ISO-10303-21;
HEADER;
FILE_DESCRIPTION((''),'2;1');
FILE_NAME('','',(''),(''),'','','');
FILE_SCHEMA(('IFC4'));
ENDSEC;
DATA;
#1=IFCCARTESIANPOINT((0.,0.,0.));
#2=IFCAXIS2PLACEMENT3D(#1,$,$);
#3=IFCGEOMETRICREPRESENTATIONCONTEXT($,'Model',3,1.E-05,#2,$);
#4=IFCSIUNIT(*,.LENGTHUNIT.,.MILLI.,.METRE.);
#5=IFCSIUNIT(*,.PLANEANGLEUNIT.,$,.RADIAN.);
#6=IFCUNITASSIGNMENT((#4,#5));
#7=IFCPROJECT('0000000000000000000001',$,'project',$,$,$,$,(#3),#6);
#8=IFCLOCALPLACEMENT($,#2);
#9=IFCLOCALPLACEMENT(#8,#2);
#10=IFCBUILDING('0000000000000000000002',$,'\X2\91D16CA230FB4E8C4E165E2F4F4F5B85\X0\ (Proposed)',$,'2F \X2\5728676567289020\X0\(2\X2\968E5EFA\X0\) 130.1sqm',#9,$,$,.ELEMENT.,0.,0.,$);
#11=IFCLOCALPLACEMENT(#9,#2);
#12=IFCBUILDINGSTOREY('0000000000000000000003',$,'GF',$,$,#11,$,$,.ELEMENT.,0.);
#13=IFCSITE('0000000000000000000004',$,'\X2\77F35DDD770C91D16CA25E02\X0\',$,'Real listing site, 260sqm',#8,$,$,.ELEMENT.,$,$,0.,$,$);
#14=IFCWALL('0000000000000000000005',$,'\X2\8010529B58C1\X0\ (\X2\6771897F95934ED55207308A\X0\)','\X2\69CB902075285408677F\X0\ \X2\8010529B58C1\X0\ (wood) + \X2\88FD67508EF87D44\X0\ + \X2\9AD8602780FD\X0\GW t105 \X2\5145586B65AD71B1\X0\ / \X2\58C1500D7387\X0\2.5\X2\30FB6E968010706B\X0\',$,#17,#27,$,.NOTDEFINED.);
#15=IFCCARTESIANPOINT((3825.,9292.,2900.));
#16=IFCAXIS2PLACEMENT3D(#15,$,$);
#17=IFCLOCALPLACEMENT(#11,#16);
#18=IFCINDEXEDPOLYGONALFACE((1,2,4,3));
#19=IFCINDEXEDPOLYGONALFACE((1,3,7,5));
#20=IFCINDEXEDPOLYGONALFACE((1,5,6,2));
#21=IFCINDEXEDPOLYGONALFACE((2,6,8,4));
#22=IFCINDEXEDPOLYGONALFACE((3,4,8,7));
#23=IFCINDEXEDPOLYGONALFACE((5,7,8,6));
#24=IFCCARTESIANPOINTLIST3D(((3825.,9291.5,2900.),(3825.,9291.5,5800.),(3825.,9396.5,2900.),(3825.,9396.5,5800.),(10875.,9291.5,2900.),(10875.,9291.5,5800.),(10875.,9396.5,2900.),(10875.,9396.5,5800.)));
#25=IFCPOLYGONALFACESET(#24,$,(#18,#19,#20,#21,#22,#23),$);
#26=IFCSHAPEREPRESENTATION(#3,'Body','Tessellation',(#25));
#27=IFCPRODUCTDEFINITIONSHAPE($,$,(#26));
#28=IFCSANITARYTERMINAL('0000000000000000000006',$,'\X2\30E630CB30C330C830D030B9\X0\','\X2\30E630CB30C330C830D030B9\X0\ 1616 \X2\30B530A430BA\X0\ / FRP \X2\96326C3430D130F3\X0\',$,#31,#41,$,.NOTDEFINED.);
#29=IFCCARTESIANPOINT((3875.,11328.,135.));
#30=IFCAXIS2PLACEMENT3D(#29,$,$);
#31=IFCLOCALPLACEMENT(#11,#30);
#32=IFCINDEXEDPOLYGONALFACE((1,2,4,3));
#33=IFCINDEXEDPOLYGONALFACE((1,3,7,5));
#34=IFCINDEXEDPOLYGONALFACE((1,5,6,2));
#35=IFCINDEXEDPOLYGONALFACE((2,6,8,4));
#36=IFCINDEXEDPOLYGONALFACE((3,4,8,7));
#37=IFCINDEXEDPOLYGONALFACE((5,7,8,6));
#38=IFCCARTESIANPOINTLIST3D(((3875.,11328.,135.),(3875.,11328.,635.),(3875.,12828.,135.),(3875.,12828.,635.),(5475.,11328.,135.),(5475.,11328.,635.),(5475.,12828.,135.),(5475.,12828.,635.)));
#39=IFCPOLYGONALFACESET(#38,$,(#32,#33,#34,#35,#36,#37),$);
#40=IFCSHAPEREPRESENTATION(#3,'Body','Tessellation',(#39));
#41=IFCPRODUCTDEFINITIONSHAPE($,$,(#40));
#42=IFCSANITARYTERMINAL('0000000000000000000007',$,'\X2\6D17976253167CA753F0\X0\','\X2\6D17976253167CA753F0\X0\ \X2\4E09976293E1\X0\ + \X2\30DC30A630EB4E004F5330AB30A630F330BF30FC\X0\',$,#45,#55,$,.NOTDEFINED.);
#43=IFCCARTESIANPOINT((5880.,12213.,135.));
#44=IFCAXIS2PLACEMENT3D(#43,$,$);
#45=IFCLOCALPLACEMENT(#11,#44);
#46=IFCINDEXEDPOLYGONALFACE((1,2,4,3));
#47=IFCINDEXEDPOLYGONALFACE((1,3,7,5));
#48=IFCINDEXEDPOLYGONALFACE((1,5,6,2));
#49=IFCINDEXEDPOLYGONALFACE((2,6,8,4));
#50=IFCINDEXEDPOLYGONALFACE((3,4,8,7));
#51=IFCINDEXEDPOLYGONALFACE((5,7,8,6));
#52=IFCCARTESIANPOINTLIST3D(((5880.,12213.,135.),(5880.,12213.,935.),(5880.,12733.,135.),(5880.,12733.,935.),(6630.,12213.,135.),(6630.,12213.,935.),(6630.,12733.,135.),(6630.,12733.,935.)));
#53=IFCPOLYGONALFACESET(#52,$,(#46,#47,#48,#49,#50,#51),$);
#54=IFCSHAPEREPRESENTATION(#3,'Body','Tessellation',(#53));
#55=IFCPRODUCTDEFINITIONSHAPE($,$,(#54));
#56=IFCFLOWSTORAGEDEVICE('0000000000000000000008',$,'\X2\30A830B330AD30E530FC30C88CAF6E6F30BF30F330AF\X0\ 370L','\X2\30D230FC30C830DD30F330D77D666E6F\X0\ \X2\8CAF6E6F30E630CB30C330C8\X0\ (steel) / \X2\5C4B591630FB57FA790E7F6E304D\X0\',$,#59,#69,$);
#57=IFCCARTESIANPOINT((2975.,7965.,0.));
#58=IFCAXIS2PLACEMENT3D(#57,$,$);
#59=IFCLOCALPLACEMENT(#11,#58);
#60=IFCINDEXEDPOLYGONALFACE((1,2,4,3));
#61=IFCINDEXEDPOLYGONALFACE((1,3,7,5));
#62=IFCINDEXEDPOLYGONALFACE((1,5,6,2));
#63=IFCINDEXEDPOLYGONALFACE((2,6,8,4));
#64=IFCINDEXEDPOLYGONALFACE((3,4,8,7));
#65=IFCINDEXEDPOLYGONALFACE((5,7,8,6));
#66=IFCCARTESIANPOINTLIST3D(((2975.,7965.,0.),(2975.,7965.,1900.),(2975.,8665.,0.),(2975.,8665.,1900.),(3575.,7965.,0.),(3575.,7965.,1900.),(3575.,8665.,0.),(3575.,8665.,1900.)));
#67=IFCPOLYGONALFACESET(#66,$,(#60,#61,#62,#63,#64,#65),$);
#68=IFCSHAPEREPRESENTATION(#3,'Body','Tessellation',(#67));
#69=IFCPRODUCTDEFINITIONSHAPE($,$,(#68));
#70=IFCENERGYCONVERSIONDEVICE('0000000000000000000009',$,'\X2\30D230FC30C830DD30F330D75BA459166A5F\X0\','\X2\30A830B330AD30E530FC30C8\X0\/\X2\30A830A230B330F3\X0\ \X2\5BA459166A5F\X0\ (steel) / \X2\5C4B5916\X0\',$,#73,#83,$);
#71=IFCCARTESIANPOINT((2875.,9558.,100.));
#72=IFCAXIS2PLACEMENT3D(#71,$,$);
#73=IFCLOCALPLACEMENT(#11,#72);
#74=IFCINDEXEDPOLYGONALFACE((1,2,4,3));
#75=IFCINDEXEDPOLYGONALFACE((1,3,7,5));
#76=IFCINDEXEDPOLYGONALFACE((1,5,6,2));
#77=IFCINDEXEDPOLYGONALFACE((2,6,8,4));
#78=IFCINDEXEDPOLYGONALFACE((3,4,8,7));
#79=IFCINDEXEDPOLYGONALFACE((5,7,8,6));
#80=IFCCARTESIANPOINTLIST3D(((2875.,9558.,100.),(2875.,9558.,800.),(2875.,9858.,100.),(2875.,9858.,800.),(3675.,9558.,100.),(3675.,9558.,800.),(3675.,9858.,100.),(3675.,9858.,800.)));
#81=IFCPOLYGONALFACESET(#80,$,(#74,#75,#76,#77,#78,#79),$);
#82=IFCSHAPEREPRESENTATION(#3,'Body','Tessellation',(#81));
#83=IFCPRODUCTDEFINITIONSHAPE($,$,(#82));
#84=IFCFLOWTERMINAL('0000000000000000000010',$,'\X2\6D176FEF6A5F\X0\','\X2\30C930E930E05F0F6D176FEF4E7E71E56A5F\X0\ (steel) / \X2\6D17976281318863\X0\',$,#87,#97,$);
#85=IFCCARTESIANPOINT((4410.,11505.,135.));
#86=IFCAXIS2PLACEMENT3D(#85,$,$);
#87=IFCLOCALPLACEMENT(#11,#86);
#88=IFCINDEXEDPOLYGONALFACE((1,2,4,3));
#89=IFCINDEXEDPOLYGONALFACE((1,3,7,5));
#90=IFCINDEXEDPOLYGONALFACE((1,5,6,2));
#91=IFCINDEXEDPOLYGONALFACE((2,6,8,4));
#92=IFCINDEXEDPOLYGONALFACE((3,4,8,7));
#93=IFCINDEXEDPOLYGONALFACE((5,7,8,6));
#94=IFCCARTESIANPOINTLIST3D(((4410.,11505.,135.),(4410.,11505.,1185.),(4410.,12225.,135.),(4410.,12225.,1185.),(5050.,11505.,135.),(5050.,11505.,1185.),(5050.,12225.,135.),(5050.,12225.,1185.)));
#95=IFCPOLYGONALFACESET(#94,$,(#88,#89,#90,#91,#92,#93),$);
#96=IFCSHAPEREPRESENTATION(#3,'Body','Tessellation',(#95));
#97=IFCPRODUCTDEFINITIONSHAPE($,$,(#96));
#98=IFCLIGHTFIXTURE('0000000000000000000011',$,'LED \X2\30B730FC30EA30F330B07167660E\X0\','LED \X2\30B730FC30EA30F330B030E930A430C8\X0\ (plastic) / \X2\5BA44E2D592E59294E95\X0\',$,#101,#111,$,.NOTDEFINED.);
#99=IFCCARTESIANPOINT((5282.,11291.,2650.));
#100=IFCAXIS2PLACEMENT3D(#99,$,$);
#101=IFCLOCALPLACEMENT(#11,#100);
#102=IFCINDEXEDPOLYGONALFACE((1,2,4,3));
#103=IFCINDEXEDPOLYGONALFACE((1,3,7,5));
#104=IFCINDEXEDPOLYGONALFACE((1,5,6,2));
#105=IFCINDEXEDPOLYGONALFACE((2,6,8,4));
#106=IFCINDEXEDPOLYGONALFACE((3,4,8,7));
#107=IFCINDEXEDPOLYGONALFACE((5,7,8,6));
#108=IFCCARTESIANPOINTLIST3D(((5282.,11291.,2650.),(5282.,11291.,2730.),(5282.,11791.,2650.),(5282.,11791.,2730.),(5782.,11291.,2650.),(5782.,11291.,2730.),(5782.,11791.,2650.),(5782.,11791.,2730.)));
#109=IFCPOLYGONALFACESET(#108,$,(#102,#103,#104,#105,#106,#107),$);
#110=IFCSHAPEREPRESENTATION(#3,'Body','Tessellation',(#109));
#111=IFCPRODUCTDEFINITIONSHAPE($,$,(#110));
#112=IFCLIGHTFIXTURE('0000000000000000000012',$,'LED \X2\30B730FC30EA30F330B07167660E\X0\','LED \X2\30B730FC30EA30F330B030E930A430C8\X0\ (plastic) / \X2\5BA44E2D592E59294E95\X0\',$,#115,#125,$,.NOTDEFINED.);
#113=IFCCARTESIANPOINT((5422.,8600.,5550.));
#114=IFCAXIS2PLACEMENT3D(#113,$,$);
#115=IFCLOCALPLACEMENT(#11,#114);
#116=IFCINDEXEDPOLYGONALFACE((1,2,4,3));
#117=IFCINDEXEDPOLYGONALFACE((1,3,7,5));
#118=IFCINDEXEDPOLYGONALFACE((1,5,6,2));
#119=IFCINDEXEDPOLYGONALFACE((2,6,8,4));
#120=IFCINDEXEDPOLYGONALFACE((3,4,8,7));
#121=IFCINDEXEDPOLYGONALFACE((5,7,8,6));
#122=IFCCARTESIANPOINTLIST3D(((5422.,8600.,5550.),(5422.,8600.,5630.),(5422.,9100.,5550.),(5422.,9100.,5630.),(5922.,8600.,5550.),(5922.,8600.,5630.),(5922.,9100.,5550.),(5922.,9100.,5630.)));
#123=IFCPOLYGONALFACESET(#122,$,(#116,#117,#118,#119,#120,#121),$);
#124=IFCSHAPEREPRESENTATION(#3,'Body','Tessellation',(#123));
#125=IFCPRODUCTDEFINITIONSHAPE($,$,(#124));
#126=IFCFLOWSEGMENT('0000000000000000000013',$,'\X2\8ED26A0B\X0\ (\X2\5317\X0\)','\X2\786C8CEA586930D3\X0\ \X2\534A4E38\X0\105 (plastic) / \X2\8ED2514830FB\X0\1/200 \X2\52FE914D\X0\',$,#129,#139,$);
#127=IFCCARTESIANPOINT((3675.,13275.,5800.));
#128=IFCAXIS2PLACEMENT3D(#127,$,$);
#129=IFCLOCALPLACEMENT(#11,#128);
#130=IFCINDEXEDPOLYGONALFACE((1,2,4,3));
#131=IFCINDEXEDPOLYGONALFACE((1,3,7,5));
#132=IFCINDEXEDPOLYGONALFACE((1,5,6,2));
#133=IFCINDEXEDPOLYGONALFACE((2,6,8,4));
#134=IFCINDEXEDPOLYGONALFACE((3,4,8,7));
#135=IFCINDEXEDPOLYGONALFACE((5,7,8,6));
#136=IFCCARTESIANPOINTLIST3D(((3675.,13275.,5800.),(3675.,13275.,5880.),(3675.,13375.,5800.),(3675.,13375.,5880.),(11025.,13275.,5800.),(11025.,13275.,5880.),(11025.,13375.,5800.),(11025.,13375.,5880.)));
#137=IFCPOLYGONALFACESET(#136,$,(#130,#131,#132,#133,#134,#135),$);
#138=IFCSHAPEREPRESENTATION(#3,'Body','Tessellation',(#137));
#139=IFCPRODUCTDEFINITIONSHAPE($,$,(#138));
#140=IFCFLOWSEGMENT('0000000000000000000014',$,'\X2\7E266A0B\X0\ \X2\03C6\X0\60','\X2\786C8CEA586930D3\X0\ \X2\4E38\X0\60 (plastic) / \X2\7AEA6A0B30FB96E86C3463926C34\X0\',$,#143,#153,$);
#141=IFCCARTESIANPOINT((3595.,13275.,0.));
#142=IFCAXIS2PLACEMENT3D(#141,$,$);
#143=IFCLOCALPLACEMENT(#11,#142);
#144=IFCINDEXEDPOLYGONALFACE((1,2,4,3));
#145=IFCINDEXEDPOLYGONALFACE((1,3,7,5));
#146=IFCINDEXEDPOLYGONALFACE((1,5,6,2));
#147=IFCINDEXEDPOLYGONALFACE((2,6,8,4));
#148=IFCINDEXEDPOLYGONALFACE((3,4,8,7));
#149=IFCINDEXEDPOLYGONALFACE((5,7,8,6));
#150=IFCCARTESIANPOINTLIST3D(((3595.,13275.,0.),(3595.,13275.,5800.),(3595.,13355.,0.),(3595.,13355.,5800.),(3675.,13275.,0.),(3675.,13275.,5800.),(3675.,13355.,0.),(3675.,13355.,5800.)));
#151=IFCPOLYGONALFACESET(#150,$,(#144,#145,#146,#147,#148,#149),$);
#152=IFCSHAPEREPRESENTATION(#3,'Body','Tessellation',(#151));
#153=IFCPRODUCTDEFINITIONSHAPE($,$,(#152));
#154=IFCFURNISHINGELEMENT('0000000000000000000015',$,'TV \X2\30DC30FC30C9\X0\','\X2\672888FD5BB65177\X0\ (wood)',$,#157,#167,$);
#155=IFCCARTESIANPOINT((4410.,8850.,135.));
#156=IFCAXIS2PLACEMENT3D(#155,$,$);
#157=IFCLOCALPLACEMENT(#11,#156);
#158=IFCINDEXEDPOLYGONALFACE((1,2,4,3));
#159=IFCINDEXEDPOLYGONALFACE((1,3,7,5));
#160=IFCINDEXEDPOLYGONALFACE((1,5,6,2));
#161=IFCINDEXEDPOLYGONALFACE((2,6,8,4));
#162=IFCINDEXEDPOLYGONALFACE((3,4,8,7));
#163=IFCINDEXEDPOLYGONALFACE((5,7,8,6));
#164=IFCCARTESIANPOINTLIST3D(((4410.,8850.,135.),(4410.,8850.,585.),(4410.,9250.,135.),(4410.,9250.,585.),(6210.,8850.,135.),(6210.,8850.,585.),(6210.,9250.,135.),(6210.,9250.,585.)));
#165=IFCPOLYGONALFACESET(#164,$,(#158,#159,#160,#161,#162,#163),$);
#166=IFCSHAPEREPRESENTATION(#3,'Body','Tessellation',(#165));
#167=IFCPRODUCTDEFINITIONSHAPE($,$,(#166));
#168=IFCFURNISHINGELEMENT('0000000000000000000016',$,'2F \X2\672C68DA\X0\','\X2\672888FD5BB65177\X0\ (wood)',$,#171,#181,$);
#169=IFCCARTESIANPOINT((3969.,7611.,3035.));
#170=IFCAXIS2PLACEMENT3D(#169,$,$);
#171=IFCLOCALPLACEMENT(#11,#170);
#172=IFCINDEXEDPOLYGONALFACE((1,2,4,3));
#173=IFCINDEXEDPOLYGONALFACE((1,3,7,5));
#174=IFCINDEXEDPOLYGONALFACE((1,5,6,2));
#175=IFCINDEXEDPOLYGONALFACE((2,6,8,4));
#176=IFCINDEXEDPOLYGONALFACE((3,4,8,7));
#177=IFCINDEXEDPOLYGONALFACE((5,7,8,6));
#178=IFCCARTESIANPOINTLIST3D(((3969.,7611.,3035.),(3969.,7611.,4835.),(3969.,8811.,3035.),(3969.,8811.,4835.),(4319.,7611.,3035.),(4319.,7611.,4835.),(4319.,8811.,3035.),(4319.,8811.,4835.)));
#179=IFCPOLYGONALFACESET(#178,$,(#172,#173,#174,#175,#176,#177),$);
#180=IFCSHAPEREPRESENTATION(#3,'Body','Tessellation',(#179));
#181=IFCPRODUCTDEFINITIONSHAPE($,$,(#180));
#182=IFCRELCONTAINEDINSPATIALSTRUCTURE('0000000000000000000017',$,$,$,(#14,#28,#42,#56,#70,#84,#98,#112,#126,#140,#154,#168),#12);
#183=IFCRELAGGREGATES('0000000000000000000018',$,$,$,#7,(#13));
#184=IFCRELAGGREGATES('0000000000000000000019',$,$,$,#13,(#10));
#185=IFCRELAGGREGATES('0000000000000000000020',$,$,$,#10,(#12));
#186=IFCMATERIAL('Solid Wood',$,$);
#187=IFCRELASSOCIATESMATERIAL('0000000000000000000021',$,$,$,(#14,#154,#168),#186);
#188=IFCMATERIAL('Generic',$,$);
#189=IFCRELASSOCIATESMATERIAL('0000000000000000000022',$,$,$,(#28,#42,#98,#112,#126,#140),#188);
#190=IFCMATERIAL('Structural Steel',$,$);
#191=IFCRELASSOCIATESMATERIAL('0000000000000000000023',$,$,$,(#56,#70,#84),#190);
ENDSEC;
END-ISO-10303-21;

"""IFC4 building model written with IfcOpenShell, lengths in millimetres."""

from ifc_helpers import new_model, si_unit, frame, frame_2d, origin, place, context, project, spatial, rectangle, extrude, material, element, save


model = new_model("IFC4")

# Units and contexts
model_context = context("Model", 3, precision=1e-05, world=origin())
ifc_project = project(units=[si_unit("LENGTHUNIT", "METRE", prefix="MILLI"), si_unit("PLANEANGLEUNIT", "RADIAN")], contexts=[model_context])

# Site, building, storey
site_placement = place(None, origin())
site = spatial("IfcSite", under=ifc_project, at=site_placement, Name="石川県金沢市", ObjectType="Real listing site, 260sqm", CompositionType="ELEMENT", RefElevation=0.0)
building_placement = place(site_placement, origin())
building = spatial("IfcBuilding", under=site, at=building_placement, Name="金沢・二世帯住宅 (Proposed)", ObjectType="2F 在来木造(2階建) 130.1sqm", CompositionType="ELEMENT", ElevationOfRefHeight=0.0, ElevationOfTerrain=0.0)
storey_placement = place(building_placement, origin())
storey = spatial("IfcBuildingStorey", under=building, at=storey_placement, Name="GF", CompositionType="ELEMENT", Elevation=0.0)

# Shared definitions
ifc_material_1 = material(Name="Solid Wood")

# Wall
wall_1_placement = place(storey_placement, frame((3825.0, 9292.0, 2900.0)))
element("IfcWall", 1, at=wall_1_placement, inside=storey, material=ifc_material_1, Name="耐力壁 (東西間仕切り)", Description="構造用合板 耐力壁 (wood) + 製材軸組 + 高性能GW t105 充填断熱 / 壁倍率2.5・準耐火", PredefinedType="NOTDEFINED", context=model_context, shape_type="SweptSolid", body=[
    extrude(rectangle(XDim=7050.0, YDim=105.0, at=frame_2d((3525.0, 52.0))), frame((3825.0, 9292.0, 2900.0)), (0.0, 0.0, 1.0), 2900.0),
])

# Sanitary terminals
ifc_material_2 = material(Name="Generic")
sanitary_terminal_1_placement = place(storey_placement, frame((3875.0, 11328.0, 135.0)))
element("IfcSanitaryTerminal", 2, at=sanitary_terminal_1_placement, inside=storey, material=ifc_material_2, Name="ユニットバス", Description="ユニットバス 1616 サイズ / FRP 防水パン", PredefinedType="NOTDEFINED", context=model_context, shape_type="SweptSolid", body=[
    extrude(rectangle(XDim=1600.0, YDim=1500.0, at=frame_2d((800.0, 750.0))), frame((3875.0, 11328.0, 135.0)), (0.0, 0.0, 1.0), 500.0),
])
sanitary_terminal_2_placement = place(storey_placement, frame((5880.0, 12213.0, 135.0)))
element("IfcSanitaryTerminal", 3, at=sanitary_terminal_2_placement, inside=storey, material=ifc_material_2, Name="洗面化粧台", Description="洗面化粧台 三面鏡 + ボウル一体カウンター", PredefinedType="NOTDEFINED", context=model_context, shape_type="SweptSolid", body=[
    extrude(rectangle(XDim=750.0, YDim=520.0, at=frame_2d((375.0, 260.0))), frame((5880.0, 12213.0, 135.0)), (0.0, 0.0, 1.0), 800.0),
])

# Flow storage device
ifc_material_3 = material(Name="Structural Steel")
flow_storage_device_placement = place(storey_placement, frame((2975.0, 7965.0, 0.0)))
element("IfcFlowStorageDevice", 4, at=flow_storage_device_placement, inside=storey, material=ifc_material_3, Name="エコキュート貯湯タンク 370L", Description="ヒートポンプ給湯 貯湯ユニット (steel) / 屋外・基礎置き", context=model_context, shape_type="SweptSolid", body=[
    extrude(rectangle(XDim=600.0, YDim=700.0, at=frame_2d((300.0, 350.0))), frame((2975.0, 7965.0, 0.0)), (0.0, 0.0, 1.0), 1900.0),
])

# Energy conversion device
energy_conversion_device_placement = place(storey_placement, frame((2875.0, 9558.0, 100.0)))
element("IfcEnergyConversionDevice", 5, at=energy_conversion_device_placement, inside=storey, material=ifc_material_3, Name="ヒートポンプ室外機", Description="エコキュート/エアコン 室外機 (steel) / 屋外", context=model_context, shape_type="SweptSolid", body=[
    extrude(rectangle(XDim=800.0, YDim=300.0, at=frame_2d((400.0, 150.0))), frame((2875.0, 9558.0, 100.0)), (0.0, 0.0, 1.0), 700.0),
])

# Flow terminal
flow_terminal_placement = place(storey_placement, frame((4410.0, 11505.0, 135.0)))
element("IfcFlowTerminal", 6, at=flow_terminal_placement, inside=storey, material=ifc_material_3, Name="洗濯機", Description="ドラム式洗濯乾燥機 (steel) / 洗面脱衣", context=model_context, shape_type="SweptSolid", body=[
    extrude(rectangle(XDim=640.0, YDim=720.0, at=frame_2d((320.0, 360.0))), frame((4410.0, 11505.0, 135.0)), (0.0, 0.0, 1.0), 1050.0),
])

# Light fixtures
light_fixture_1_placement = place(storey_placement, frame((5282.0, 11291.0, 2650.0)))
element("IfcLightFixture", 7, at=light_fixture_1_placement, inside=storey, material=ifc_material_2, Name="LED シーリング照明", Description="LED シーリングライト (plastic) / 室中央天井", PredefinedType="NOTDEFINED", context=model_context, shape_type="SweptSolid", body=[
    extrude(rectangle(XDim=500.0, YDim=500.0, at=frame_2d((250.0, 250.0))), frame((5282.0, 11291.0, 2650.0)), (0.0, 0.0, 1.0), 80.0),
])
light_fixture_2_placement = place(storey_placement, frame((5422.0, 8600.0, 5550.0)))
element("IfcLightFixture", 8, at=light_fixture_2_placement, inside=storey, material=ifc_material_2, Name="LED シーリング照明", Description="LED シーリングライト (plastic) / 室中央天井", PredefinedType="NOTDEFINED", context=model_context, shape_type="SweptSolid", body=[
    extrude(rectangle(XDim=500.0, YDim=500.0, at=frame_2d((250.0, 250.0))), frame((5422.0, 8600.0, 5550.0)), (0.0, 0.0, 1.0), 80.0),
])

# Flow segments
flow_segment_1_placement = place(storey_placement, frame((3675.0, 13275.0, 5800.0)))
element("IfcFlowSegment", 9, at=flow_segment_1_placement, inside=storey, material=ifc_material_2, Name="軒樋 (北)", Description="硬質塩ビ 半丸105 (plastic) / 軒先・1/200 勾配", context=model_context, shape_type="SweptSolid", body=[
    extrude(rectangle(XDim=7350.0, YDim=100.0, at=frame_2d((3675.0, 50.0))), frame((3675.0, 13275.0, 5800.0)), (0.0, 0.0, 1.0), 80.0),
])
flow_segment_2_placement = place(storey_placement, frame((3595.0, 13275.0, 0.0)))
element("IfcFlowSegment", 10, at=flow_segment_2_placement, inside=storey, material=ifc_material_2, Name="縦樋 φ60", Description="硬質塩ビ 丸60 (plastic) / 竪樋・雨水排水", context=model_context, shape_type="SweptSolid", body=[
    extrude(rectangle(XDim=80.0, YDim=80.0, at=frame_2d((40.0, 40.0))), frame((3595.0, 13275.0, 0.0)), (0.0, 0.0, 1.0), 5800.0),
])

# Furnishing elements
furnishing_1_placement = place(storey_placement, frame((4410.0, 8850.0, 135.0)))
element("IfcFurnishingElement", 11, at=furnishing_1_placement, inside=storey, material=ifc_material_1, Name="TV ボード", Description="木製家具 (wood)", context=model_context, shape_type="SweptSolid", body=[
    extrude(rectangle(XDim=1800.0, YDim=400.0, at=frame_2d((900.0, 200.0))), frame((4410.0, 8850.0, 135.0)), (0.0, 0.0, 1.0), 450.0),
])
furnishing_2_placement = place(storey_placement, frame((3969.0, 7611.0, 3035.0)))
element("IfcFurnishingElement", 12, at=furnishing_2_placement, inside=storey, material=ifc_material_1, Name="2F 本棚", Description="木製家具 (wood)", context=model_context, shape_type="SweptSolid", body=[
    extrude(rectangle(XDim=350.0, YDim=1200.0, at=frame_2d((175.0, 600.0))), frame((3969.0, 7611.0, 3035.0)), (0.0, 0.0, 1.0), 1800.0),
])

save(model, "model.ifc")
